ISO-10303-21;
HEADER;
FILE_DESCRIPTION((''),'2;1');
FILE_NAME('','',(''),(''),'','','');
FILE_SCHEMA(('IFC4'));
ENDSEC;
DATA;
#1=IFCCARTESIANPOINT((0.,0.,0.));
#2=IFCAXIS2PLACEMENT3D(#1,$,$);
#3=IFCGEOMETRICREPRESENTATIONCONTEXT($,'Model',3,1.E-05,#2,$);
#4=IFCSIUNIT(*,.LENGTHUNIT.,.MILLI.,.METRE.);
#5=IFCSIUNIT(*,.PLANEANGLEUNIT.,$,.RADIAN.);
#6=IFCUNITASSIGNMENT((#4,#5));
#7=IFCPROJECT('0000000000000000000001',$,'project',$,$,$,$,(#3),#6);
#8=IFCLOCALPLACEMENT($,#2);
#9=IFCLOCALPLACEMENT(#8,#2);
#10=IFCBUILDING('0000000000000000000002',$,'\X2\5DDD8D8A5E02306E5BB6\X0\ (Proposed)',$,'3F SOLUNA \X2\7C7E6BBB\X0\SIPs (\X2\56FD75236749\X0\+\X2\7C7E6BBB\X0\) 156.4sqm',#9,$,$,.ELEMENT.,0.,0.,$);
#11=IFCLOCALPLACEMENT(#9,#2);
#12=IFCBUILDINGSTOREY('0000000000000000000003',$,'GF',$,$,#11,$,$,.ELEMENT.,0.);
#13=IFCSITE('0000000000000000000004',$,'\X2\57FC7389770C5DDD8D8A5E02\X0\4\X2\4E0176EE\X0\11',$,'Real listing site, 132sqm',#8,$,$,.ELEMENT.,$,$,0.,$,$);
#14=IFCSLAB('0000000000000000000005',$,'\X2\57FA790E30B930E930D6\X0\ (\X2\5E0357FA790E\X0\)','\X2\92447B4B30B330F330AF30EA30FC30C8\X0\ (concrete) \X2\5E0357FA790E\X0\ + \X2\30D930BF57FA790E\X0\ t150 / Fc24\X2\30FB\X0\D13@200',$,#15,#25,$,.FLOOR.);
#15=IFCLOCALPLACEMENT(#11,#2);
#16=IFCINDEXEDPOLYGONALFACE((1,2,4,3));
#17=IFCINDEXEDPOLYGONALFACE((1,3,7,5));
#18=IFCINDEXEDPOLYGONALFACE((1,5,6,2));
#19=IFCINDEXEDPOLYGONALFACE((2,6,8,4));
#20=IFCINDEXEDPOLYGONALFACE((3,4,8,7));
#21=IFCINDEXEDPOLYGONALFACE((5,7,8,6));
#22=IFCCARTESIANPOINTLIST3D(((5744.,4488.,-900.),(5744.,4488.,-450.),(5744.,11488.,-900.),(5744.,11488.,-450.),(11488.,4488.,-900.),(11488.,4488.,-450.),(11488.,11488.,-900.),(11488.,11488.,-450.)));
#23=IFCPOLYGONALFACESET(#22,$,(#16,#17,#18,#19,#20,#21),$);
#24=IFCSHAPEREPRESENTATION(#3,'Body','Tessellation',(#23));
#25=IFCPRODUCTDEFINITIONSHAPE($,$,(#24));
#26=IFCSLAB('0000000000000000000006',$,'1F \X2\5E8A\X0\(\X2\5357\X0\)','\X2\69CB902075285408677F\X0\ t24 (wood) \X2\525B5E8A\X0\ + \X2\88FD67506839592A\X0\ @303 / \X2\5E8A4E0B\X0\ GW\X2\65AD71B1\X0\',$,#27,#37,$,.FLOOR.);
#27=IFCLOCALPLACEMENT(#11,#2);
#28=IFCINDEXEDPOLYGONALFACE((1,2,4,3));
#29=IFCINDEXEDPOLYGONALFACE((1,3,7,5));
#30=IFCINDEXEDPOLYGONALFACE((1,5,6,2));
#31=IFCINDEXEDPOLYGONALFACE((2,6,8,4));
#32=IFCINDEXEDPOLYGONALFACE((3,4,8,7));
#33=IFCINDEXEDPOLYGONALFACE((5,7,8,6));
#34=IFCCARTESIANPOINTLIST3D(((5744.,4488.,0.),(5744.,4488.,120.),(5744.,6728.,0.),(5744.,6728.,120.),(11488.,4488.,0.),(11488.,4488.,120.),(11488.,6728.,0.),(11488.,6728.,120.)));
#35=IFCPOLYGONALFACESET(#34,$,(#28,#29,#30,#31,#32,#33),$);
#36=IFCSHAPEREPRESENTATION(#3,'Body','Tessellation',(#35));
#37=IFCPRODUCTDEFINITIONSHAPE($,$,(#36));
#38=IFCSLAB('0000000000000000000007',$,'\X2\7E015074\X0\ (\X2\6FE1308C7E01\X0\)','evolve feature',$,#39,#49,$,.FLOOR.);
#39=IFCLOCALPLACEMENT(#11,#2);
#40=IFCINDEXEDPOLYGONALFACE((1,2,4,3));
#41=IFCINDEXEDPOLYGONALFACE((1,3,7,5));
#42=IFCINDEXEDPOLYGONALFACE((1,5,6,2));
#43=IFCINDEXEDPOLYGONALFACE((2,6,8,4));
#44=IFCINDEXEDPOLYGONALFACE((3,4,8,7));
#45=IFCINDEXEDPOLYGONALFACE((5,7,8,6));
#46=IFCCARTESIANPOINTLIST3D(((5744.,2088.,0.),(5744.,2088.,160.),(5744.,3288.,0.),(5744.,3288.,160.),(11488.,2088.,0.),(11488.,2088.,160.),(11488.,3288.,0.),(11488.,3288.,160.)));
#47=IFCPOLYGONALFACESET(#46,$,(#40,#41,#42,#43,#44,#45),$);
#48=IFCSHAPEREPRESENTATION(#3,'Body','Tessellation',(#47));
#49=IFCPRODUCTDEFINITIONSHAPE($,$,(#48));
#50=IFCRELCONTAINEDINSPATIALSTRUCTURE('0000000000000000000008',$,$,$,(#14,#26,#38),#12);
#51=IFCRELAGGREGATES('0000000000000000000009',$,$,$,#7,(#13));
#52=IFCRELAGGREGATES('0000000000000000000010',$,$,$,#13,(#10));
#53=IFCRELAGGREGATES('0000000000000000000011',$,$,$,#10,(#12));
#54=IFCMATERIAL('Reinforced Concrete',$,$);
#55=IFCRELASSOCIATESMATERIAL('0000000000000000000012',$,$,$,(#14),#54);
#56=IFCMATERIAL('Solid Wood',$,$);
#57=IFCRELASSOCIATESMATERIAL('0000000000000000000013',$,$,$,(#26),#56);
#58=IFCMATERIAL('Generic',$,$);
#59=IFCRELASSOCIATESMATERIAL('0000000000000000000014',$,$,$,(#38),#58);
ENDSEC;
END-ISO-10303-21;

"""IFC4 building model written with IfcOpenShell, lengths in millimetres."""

from ifc_helpers import new_model, si_unit, frame, frame_2d, origin, place, context, project, spatial, rectangle, extrude, material, element, save


model = new_model("IFC4")

# Units and contexts
model_context = context("Model", 3, precision=1e-05, world=origin())
ifc_project = project(units=[si_unit("LENGTHUNIT", "METRE", prefix="MILLI"), si_unit("PLANEANGLEUNIT", "RADIAN")], contexts=[model_context])

# Site, building, storey
site_placement = place(None, origin())
site = spatial("IfcSite", under=ifc_project, at=site_placement, Name="埼玉県川越市4丁目11", ObjectType="Real listing site, 132sqm", CompositionType="ELEMENT", RefElevation=0.0)
building_placement = place(site_placement, origin())
building = spatial("IfcBuilding", under=site, at=building_placement, Name="川越市の家 (Proposed)", ObjectType="3F SOLUNA 籾殻SIPs (国産杉+籾殻) 156.4sqm", CompositionType="ELEMENT", ElevationOfRefHeight=0.0, ElevationOfTerrain=0.0)
storey_placement = place(building_placement, origin())
storey = spatial("IfcBuildingStorey", under=building, at=storey_placement, Name="GF", CompositionType="ELEMENT", Elevation=0.0)

# Slabs
ifc_material_1 = material(Name="Reinforced Concrete")
slab_1_placement = place(storey_placement, frame((2872.0, 2244.0, -450.0)))
element("IfcSlab", 1, at=slab_1_placement, inside=storey, material=ifc_material_1, Name="基礎スラブ (布基礎)", Description="鉄筋コンクリート (concrete) 布基礎 + ベタ基礎 t150 / Fc24・D13@200", PredefinedType="FLOOR", context=model_context, shape_type="SweptSolid", body=[
    extrude(rectangle(XDim=5744.0, YDim=7000.0, at=frame_2d((2872.0, 3500.0))), frame((2872.0, 2244.0, -450.0)), (0.0, 0.0, 1.0), 450.0),
])
ifc_material_2 = material(Name="Solid Wood")
slab_2_placement = place(storey_placement, frame((2872.0, 2244.0, 0.0)))
element("IfcSlab", 2, at=slab_2_placement, inside=storey, material=ifc_material_2, Name="1F 床(南)", Description="構造用合板 t24 (wood) 剛床 + 製材根太 @303 / 床下 GW断熱", PredefinedType="FLOOR", context=model_context, shape_type="SweptSolid", body=[
    extrude(rectangle(XDim=5744.0, YDim=2240.0, at=frame_2d((2872.0, 1120.0))), frame((2872.0, 2244.0, 0.0)), (0.0, 0.0, 1.0), 120.0),
])
ifc_material_3 = material(Name="Generic")
slab_3_placement = place(storey_placement, frame((2872.0, 1044.0, 0.0)))
element("IfcSlab", 3, at=slab_3_placement, inside=storey, material=ifc_material_3, Name="縁側 (濡れ縁)", Description="evolve feature", PredefinedType="FLOOR", context=model_context, shape_type="SweptSolid", body=[
    extrude(rectangle(XDim=5744.0, YDim=1200.0, at=frame_2d((2872.0, 600.0))), frame((2872.0, 1044.0, 0.0)), (0.0, 0.0, 1.0), 160.0),
])

save(model, "model.ifc")
